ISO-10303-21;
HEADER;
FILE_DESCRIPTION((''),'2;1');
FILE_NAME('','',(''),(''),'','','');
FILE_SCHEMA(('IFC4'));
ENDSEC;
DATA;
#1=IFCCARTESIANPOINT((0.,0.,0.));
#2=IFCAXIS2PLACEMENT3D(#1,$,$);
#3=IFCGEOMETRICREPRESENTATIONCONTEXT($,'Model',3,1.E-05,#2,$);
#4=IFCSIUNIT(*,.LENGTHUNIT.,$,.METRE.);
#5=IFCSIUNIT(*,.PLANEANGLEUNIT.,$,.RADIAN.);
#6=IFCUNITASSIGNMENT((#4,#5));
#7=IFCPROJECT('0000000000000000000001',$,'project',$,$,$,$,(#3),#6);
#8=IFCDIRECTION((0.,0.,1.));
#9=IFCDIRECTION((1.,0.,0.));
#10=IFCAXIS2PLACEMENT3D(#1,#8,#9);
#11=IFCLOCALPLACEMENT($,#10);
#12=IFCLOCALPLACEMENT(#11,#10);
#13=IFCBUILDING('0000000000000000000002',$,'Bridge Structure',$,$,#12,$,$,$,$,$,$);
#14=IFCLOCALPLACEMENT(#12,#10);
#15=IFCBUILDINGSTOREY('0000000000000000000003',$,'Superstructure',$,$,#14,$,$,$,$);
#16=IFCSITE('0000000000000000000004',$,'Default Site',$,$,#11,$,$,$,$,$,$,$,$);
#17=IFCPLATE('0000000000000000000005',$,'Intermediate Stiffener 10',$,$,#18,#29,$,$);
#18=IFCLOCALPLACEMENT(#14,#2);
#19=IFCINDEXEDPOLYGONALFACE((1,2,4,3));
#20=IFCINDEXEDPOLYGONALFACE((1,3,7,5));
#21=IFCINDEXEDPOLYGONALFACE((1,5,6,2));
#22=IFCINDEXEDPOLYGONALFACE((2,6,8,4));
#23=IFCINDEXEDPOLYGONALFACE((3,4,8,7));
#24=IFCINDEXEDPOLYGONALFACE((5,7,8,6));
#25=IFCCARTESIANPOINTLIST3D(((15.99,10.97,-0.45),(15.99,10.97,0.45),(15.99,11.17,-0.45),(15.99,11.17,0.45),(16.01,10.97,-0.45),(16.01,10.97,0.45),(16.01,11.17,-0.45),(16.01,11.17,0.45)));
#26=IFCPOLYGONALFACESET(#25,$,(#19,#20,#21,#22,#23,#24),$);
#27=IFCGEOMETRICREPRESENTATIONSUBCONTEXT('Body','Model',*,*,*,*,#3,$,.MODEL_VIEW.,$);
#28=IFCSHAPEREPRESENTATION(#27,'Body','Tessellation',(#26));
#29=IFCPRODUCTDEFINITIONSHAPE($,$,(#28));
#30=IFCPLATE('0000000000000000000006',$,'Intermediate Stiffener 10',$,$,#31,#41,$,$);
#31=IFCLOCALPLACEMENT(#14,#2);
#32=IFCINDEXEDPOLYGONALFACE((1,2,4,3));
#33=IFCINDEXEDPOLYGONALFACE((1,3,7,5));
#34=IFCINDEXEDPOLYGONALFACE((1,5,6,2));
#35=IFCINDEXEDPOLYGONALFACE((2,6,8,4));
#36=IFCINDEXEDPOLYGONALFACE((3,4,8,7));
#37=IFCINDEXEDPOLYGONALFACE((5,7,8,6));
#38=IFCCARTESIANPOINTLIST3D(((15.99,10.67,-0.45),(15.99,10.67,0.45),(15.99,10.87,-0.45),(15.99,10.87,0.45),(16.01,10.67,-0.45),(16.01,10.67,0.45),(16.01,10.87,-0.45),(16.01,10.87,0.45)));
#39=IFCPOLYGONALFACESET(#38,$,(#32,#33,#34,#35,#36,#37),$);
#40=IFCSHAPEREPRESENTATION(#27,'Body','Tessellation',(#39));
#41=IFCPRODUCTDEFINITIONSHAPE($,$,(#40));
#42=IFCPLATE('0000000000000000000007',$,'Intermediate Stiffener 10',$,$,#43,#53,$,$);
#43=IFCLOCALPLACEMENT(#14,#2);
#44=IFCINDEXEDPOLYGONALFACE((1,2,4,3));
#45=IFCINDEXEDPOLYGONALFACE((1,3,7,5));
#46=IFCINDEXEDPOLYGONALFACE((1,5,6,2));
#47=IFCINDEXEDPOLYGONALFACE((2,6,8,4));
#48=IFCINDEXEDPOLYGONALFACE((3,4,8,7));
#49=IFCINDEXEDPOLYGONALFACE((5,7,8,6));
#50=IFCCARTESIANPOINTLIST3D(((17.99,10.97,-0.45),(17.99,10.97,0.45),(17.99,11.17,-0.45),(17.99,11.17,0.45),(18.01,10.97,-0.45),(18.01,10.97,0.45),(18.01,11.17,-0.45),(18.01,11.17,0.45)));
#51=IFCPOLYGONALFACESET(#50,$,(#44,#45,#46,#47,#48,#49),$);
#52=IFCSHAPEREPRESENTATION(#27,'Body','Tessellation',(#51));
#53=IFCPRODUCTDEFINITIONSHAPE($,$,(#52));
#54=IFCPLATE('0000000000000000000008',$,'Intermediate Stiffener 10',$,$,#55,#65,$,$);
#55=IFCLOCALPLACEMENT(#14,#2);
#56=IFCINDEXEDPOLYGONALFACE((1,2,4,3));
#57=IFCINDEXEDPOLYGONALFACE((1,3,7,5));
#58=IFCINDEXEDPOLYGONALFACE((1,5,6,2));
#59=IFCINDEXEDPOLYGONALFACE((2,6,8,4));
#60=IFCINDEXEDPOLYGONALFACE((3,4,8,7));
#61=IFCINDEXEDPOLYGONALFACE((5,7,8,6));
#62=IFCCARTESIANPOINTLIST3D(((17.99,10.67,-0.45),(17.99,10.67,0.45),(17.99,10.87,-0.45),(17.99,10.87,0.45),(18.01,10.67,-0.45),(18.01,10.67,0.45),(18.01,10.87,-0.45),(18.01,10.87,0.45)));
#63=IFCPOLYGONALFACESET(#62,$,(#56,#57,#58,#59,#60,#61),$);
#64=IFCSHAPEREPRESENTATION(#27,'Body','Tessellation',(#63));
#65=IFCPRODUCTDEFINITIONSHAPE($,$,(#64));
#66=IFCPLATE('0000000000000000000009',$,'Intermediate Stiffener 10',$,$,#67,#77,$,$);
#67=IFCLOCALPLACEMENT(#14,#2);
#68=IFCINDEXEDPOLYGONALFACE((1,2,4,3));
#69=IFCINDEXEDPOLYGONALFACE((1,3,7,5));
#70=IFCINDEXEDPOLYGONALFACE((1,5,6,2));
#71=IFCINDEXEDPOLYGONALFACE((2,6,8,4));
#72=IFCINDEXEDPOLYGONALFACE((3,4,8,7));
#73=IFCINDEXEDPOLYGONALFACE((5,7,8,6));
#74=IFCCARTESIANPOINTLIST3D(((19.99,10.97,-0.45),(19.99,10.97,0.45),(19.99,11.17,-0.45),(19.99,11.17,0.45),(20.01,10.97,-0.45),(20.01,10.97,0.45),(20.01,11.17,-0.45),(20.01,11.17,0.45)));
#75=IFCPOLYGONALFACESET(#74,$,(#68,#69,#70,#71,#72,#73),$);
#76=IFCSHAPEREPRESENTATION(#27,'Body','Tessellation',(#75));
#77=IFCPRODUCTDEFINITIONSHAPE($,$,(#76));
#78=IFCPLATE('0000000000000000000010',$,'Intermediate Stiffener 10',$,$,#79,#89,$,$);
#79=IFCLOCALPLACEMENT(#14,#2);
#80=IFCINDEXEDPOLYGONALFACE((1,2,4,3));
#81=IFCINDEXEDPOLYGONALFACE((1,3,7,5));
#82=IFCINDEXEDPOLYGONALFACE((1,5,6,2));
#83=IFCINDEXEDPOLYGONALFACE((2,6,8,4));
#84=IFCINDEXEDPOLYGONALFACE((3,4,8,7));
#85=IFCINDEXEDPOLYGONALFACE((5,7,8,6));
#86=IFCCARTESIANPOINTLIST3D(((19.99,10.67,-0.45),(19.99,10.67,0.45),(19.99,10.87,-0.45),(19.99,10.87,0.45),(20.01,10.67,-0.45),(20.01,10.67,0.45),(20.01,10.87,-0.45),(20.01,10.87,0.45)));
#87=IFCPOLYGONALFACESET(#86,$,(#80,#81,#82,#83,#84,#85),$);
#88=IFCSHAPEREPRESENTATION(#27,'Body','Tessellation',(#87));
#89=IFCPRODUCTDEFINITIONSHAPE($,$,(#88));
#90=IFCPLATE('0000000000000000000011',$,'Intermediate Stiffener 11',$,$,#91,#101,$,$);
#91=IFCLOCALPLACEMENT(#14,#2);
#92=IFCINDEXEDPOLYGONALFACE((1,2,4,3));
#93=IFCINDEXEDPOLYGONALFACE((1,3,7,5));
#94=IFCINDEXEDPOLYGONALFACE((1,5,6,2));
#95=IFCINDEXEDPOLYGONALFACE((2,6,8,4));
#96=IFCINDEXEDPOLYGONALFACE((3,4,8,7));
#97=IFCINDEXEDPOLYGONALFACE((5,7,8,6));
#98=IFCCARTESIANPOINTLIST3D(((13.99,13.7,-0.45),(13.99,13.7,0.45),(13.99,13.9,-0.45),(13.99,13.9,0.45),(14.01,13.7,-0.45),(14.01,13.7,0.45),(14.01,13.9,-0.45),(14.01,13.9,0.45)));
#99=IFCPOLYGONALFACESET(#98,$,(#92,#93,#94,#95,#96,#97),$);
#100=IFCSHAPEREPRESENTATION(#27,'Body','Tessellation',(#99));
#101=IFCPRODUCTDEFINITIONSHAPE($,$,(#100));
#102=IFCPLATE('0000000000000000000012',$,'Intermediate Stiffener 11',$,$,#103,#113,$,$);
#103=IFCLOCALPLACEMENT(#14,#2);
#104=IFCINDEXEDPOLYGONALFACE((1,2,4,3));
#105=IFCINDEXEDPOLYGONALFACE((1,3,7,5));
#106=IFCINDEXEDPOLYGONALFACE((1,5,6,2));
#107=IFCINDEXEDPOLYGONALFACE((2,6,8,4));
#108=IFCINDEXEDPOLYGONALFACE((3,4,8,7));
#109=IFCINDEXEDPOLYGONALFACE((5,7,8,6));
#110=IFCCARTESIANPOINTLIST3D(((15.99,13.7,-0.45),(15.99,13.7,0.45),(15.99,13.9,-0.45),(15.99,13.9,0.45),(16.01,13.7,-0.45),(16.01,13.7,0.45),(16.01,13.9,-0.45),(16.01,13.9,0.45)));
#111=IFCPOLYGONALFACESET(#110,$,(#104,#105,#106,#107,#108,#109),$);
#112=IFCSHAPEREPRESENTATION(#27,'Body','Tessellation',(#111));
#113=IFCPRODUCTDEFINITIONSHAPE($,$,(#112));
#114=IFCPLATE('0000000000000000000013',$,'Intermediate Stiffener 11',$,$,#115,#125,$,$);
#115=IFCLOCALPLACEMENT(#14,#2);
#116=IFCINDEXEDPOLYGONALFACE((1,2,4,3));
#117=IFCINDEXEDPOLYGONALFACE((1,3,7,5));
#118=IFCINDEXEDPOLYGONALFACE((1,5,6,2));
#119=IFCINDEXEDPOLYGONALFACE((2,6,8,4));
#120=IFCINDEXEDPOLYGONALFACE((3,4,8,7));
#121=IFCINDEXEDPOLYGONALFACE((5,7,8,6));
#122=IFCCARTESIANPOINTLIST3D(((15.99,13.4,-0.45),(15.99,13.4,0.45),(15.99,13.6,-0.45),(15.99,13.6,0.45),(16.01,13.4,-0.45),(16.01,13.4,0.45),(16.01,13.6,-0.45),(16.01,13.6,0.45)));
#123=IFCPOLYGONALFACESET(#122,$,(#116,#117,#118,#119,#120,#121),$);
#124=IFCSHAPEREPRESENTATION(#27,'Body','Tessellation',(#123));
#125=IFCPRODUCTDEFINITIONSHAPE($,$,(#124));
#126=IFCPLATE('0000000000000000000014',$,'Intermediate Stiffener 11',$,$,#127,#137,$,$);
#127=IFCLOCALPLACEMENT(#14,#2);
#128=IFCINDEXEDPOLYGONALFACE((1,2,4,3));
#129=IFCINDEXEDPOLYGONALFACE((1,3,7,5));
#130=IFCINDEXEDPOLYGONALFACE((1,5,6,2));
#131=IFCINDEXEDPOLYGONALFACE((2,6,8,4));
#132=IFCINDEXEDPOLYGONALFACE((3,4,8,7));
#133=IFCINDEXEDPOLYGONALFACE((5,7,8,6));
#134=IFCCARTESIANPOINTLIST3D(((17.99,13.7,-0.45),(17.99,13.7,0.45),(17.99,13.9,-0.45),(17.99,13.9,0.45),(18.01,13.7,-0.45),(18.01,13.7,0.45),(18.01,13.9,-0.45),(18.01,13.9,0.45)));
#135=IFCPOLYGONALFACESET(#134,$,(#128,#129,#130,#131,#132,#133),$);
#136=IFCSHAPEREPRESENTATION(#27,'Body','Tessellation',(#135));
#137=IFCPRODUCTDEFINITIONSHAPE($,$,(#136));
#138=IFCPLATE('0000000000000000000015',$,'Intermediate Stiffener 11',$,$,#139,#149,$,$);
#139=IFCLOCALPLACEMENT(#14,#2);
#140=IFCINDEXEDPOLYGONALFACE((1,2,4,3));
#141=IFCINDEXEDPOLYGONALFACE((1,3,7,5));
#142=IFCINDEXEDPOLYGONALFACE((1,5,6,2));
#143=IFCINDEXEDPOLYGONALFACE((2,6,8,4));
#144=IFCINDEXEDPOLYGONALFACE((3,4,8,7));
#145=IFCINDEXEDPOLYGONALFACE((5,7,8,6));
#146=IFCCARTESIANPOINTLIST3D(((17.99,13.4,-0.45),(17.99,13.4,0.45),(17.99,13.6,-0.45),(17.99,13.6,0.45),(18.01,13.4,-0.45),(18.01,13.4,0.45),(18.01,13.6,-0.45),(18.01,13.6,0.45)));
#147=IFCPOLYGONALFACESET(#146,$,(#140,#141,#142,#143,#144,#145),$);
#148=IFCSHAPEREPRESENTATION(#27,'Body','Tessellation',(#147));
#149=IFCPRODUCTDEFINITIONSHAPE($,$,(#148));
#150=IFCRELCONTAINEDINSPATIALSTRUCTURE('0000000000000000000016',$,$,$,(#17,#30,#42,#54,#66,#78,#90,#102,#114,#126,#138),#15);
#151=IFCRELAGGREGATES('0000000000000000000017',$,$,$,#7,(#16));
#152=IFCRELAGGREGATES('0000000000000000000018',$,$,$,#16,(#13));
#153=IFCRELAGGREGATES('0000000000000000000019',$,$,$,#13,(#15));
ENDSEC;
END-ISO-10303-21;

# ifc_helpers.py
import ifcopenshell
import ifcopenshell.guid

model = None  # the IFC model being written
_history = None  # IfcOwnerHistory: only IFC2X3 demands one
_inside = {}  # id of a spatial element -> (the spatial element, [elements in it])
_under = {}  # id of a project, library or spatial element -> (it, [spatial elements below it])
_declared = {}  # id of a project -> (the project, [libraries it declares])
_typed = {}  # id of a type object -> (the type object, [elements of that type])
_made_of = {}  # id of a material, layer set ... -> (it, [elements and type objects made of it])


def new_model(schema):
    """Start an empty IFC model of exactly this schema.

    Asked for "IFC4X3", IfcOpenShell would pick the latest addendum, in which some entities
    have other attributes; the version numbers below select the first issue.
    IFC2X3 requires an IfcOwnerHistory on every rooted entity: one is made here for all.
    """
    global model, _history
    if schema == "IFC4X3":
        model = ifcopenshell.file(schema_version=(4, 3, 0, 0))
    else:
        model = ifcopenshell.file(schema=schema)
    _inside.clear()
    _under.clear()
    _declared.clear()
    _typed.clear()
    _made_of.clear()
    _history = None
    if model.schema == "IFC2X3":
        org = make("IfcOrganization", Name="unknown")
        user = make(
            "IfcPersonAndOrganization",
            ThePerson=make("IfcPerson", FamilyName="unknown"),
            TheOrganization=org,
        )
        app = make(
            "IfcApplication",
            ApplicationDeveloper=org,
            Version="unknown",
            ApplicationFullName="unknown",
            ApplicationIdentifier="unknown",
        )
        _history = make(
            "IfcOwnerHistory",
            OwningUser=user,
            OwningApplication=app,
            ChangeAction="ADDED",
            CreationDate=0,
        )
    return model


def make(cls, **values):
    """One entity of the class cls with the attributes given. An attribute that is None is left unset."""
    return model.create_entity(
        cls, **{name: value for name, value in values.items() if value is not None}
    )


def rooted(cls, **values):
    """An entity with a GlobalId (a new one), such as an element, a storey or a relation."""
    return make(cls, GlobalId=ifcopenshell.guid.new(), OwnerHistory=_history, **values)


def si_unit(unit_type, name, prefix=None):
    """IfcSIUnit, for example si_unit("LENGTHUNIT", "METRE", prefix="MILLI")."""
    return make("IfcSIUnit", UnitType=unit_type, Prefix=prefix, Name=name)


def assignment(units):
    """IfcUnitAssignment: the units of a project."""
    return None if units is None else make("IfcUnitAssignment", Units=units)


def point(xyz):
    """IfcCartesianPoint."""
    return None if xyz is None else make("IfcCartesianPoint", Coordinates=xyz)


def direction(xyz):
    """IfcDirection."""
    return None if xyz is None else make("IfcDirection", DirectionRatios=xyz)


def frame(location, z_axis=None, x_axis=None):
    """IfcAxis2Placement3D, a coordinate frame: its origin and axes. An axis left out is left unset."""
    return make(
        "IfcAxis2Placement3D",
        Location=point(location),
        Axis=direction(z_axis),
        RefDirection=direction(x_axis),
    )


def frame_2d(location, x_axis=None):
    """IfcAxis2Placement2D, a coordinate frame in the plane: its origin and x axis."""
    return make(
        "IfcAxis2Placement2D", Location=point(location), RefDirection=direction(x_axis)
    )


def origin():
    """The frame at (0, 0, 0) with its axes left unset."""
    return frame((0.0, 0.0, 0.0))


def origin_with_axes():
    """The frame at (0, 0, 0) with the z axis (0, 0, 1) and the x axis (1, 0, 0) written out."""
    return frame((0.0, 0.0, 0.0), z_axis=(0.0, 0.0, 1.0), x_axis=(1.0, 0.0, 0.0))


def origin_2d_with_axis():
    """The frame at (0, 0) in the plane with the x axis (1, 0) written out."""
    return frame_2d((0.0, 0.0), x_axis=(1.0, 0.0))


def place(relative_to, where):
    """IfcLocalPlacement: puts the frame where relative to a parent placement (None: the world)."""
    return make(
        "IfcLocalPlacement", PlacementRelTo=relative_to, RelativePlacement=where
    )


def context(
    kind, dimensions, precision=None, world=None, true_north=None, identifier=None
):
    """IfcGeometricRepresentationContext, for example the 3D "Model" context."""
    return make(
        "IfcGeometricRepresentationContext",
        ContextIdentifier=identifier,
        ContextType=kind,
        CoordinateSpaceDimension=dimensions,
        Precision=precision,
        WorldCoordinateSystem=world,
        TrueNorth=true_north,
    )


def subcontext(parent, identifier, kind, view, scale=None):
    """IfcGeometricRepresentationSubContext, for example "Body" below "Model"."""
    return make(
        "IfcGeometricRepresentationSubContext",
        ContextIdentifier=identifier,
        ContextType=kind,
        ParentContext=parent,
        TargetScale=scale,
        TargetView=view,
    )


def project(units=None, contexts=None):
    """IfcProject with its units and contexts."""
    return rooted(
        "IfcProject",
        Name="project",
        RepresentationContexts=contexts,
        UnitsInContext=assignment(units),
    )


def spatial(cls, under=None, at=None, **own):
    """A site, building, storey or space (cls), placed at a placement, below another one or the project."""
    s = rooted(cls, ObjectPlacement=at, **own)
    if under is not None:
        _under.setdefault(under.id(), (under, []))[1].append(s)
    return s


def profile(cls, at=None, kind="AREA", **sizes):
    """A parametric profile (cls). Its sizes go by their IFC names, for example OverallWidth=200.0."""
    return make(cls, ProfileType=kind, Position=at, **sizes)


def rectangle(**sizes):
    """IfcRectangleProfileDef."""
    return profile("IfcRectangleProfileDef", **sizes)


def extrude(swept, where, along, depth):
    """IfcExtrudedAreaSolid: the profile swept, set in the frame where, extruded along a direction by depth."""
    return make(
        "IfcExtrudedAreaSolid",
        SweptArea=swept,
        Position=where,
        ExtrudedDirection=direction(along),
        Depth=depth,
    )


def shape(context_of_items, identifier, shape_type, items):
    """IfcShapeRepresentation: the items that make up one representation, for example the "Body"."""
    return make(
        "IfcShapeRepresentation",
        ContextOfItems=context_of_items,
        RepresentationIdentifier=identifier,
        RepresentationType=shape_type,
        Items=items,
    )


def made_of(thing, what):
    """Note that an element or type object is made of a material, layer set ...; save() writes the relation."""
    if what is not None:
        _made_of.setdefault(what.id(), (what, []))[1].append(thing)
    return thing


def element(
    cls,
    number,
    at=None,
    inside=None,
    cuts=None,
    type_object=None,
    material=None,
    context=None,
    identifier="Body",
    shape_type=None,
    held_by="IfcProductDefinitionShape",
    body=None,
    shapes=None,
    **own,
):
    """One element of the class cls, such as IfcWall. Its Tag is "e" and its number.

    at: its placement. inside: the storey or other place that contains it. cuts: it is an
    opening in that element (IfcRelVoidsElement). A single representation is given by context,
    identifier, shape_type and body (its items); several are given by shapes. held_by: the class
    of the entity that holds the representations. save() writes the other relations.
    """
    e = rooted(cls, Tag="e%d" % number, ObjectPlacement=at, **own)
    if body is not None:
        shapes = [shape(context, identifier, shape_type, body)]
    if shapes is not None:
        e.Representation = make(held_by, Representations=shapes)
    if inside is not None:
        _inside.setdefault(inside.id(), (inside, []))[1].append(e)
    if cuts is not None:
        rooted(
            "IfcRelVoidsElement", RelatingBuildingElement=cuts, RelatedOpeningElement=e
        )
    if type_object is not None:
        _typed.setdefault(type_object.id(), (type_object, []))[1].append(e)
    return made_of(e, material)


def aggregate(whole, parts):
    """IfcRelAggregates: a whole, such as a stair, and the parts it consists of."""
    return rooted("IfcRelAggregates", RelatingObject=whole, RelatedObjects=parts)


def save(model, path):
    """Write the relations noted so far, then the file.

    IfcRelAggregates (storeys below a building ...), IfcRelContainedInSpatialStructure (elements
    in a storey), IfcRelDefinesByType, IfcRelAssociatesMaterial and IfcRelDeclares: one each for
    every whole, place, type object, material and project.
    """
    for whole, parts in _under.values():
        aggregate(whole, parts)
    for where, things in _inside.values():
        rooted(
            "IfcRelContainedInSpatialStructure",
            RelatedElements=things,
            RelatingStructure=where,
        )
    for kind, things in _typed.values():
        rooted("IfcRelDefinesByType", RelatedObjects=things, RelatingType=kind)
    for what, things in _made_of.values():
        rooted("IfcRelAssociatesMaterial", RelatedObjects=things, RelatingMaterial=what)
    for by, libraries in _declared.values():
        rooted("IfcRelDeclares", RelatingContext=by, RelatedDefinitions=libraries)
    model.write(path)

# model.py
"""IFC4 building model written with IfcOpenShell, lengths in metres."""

from ifc_helpers import new_model, si_unit, frame, origin, origin_with_axes, origin_2d_with_axis, place, context, subcontext, project, spatial, rectangle, extrude, element, save


model = new_model("IFC4")

# Units and contexts
model_context = context("Model", 3, precision=1e-05, world=origin())
body_context = subcontext(model_context, "Body", "Model", "MODEL_VIEW")
ifc_project = project(units=[si_unit("LENGTHUNIT", "METRE"), si_unit("PLANEANGLEUNIT", "RADIAN")], contexts=[model_context])

# Site, building, storey
site_placement = place(None, origin_with_axes())
site = spatial("IfcSite", under=ifc_project, at=site_placement, Name="Default Site")
building_placement = place(site_placement, origin_with_axes())
building = spatial("IfcBuilding", under=site, at=building_placement, Name="Bridge Structure")
storey_placement = place(building_placement, origin_with_axes())
storey = spatial("IfcBuildingStorey", under=building, at=storey_placement, Name="Superstructure")

# Plates
for number, where, z_axis, x_axis, name in (
    (1, (16.0, 11.07, -0.45), (0.0, 0.0, 1.0), (1.0, 0.0, 0.0), "Intermediate Stiffener 10"),
    (2, (16.0, 10.77, -0.45), (0.0, 0.0, 1.0), (1.0, 0.0, 0.0), "Intermediate Stiffener 10"),
    (3, (18.0, 11.07, -0.45), (0.0, 0.0, 1.0), (1.0, 0.0, 0.0), "Intermediate Stiffener 10"),
    (4, (18.0, 10.77, -0.45), (0.0, 0.0, 1.0), (1.0, 0.0, 0.0), "Intermediate Stiffener 10"),
    (5, (20.0, 11.07, -0.45), (0.0, 0.0, 1.0), (1.0, 0.0, 0.0), "Intermediate Stiffener 10"),
    (6, (20.0, 10.77, -0.45), (0.0, 0.0, 1.0), (1.0, 0.0, 0.0), "Intermediate Stiffener 10"),
    (7, (14.0, 13.8, -0.45), (0.0, 0.0, 1.0), (1.0, 0.0, 0.0), "Intermediate Stiffener 11"),
    (8, (16.0, 13.8, -0.45), (0.0, 0.0, 1.0), (1.0, 0.0, 0.0), "Intermediate Stiffener 11"),
    (9, (16.0, 13.5, -0.45), (0.0, 0.0, 1.0), (1.0, 0.0, 0.0), "Intermediate Stiffener 11"),
    (10, (18.0, 13.8, -0.45), (0.0, 0.0, 1.0), (1.0, 0.0, 0.0), "Intermediate Stiffener 11"),
    (11, (18.0, 13.5, -0.45), (0.0, 0.0, 1.0), (1.0, 0.0, 0.0), "Intermediate Stiffener 11"),
):
    element("IfcPlate", number, at=place(storey_placement, frame(where, z_axis=z_axis, x_axis=x_axis)), inside=storey, Name=name, context=body_context, shape_type="SweptSolid", body=[
        extrude(rectangle(XDim=0.02, YDim=0.2, at=origin_2d_with_axis()), origin_with_axes(), (0.0, 0.0, 1.0), 0.9),
    ])

save(model, "model.ifc")
